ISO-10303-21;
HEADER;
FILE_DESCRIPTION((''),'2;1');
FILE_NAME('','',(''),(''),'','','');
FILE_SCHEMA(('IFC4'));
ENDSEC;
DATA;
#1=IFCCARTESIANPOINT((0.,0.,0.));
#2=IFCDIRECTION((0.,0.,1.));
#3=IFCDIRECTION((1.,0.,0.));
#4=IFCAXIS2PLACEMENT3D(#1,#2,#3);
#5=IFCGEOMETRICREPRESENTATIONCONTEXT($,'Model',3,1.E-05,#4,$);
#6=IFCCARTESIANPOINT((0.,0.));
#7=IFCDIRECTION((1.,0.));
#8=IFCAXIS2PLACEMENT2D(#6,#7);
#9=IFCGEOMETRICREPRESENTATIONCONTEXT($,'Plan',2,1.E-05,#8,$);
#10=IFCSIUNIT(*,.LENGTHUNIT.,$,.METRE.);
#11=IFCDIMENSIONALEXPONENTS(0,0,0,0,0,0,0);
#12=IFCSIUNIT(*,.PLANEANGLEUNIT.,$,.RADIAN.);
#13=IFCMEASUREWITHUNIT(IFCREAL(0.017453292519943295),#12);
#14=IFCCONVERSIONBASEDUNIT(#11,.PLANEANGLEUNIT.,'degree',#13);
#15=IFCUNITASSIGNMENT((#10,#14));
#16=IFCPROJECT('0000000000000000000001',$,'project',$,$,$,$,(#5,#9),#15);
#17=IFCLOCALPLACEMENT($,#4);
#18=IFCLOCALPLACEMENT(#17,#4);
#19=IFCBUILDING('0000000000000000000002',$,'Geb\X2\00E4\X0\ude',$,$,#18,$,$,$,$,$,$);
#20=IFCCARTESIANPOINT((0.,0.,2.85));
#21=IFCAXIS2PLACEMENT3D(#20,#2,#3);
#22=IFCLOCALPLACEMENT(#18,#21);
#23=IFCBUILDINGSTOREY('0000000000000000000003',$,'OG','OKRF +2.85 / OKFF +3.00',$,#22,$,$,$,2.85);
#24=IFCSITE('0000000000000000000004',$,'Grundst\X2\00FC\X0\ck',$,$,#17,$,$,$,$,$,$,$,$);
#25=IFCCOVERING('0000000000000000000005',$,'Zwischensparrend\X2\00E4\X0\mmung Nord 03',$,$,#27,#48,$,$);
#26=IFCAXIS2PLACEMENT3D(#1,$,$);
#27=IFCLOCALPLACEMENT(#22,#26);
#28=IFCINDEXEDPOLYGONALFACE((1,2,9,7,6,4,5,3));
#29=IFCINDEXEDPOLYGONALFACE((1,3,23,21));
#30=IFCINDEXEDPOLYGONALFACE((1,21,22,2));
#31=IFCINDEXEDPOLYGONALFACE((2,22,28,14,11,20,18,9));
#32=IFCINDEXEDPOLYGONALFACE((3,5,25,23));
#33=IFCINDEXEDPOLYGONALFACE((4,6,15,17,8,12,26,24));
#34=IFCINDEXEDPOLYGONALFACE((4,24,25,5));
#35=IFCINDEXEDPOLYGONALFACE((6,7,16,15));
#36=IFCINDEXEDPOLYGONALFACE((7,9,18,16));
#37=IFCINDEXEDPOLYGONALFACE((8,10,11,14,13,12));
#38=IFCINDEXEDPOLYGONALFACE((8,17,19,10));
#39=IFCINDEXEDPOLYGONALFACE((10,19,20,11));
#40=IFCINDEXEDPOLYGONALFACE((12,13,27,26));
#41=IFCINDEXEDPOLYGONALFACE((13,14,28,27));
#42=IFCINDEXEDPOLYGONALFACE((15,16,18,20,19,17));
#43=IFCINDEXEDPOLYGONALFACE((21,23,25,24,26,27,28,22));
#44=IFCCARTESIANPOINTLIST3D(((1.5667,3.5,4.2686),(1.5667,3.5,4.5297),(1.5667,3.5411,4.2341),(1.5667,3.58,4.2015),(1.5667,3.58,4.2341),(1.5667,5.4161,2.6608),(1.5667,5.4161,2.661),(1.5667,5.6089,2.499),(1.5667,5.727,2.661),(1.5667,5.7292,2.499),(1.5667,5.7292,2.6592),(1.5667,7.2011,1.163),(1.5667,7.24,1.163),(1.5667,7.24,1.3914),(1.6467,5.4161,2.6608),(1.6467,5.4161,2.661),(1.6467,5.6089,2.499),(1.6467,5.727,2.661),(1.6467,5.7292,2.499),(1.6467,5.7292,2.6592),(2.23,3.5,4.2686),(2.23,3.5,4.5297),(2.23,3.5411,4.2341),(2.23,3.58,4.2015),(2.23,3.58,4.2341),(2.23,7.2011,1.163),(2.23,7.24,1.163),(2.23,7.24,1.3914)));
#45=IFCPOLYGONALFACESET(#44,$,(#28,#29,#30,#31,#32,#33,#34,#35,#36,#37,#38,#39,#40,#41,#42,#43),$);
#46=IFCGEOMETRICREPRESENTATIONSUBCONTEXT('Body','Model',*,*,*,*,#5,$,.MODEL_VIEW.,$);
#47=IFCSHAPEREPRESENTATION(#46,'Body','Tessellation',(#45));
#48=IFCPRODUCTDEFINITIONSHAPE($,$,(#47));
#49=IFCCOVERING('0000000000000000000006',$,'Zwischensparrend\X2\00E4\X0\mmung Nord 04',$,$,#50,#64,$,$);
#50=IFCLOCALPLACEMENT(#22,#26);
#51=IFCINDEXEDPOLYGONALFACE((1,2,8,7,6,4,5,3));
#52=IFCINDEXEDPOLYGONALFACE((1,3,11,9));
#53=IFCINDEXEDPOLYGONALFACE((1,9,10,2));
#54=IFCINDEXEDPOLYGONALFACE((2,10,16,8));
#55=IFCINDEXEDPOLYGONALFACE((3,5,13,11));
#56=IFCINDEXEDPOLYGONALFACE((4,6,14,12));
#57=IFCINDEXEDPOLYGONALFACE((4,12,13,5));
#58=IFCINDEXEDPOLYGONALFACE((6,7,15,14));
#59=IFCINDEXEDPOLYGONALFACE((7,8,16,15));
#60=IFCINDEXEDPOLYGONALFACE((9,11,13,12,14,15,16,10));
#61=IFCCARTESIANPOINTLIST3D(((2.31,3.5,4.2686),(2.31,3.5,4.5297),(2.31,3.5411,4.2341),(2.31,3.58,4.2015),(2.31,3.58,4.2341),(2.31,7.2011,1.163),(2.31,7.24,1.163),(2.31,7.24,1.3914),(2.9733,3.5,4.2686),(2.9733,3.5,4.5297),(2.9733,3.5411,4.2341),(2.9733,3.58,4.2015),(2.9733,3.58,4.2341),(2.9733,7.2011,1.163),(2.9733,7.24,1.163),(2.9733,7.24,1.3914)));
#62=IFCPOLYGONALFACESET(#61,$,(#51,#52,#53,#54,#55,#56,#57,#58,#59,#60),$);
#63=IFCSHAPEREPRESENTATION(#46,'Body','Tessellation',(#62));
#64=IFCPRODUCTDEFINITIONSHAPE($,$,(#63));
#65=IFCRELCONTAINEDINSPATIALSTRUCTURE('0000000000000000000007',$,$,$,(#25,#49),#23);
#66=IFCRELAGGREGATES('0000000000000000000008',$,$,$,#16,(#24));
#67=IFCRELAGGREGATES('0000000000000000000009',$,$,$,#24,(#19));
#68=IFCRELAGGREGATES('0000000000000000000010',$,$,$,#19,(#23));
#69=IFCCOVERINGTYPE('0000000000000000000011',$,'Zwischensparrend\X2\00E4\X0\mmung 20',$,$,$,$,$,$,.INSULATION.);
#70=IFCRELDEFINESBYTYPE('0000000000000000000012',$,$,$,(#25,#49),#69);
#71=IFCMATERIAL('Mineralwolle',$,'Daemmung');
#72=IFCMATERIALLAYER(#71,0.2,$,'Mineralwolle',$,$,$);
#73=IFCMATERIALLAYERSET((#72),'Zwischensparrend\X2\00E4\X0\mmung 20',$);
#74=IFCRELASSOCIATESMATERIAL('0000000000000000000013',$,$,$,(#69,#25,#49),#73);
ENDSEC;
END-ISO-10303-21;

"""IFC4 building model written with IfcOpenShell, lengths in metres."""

from ifc_helpers import new_model, entity, si_unit, converted_unit, frame, origin_with_axes, origin_2d_with_axis, place, context, subcontext, project, spatial, polyline, outline, extrude, material, layer, layer_set, layer_usage, type_object, element, save


model = new_model("IFC4")

# Units and contexts
model_context = context("Model", 3, precision=1e-05, world=origin_with_axes())
plan_context = context("Plan", 2, precision=1e-05, world=origin_2d_with_axis())
body_context = subcontext(model_context, "Body", "Model", "MODEL_VIEW")
ifc_project = project(units=[si_unit("LENGTHUNIT", "METRE"), converted_unit("PLANEANGLEUNIT", "degree", entity("IfcReal", 0.017453292519943295), si_unit("PLANEANGLEUNIT", "RADIAN"), dimensions=[0, 0, 0, 0, 0, 0, 0])], contexts=[model_context, plan_context])

# Site, building, storey
site_placement = place(None, origin_with_axes())
site = spatial("IfcSite", under=ifc_project, at=site_placement, Name="Grundstück")
building_placement = place(site_placement, origin_with_axes())
building = spatial("IfcBuilding", under=site, at=building_placement, Name="Gebäude")
storey_placement = place(building_placement, frame((0.0, 0.0, 2.85), z_axis=(0.0, 0.0, 1.0), x_axis=(1.0, 0.0, 0.0)))
storey = spatial("IfcBuildingStorey", under=building, at=storey_placement, Name="OG", Description="OKRF +2.85 / OKFF +3.00", Elevation=2.85)

# Covering, opening
ifc_material_1 = material(Name="Mineralwolle", Category="Daemmung")
ifc_layer = layer(ifc_material_1, 0.2, Name="Mineralwolle")
ifc_layer_set = layer_set([ifc_layer], Name="Zwischensparrendämmung 20")
ifc_layer_usage_1 = layer_usage(ifc_layer_set, "AXIS3", "POSITIVE", 0.0)
covering_type = type_object("IfcCoveringType", Name="Zwischensparrendämmung 20", PredefinedType="INSULATION", material=ifc_layer_set)
covering_1_placement = place(storey_placement, frame((2.23, 7.24, 1.1304), z_axis=(0.0, 0.642788, 0.766044), x_axis=(-1.0, 0.0, 0.0)))
covering_1 = element("IfcCovering", 1, at=covering_1_placement, inside=storey, type_object=covering_type, material=ifc_layer_usage_1, Name="Zwischensparrendämmung Nord 03", context=body_context, shape_type="SweptSolid", body=[
    extrude(outline(polyline([(0.021, 0.025), (0.0508, 0.0), (4.7778, 0.0), (4.7988, 0.025), (4.8286, 0.0), (4.8822, 0.0), (5.05, 0.2), (0.1678, 0.2), (0.021, 0.025)])), frame((0.0, 0.0, 0.0), z_axis=(1.0, 0.0, 0.0), x_axis=(0.0, 1.0, 0.0)), (0.0, 0.0, 1.0), 0.6633),
])
opening_1_placement = place(covering_1_placement, frame((2.23, 2.9876, -7.7029), z_axis=(0.0, 0.642788, 0.766044), x_axis=(-1.0, 0.0, 0.0)))
element("IfcOpeningElement", 2, at=opening_1_placement, cuts=covering_1, PredefinedType="RECESS", context=body_context, shape_type="SweptSolid", body=[
    extrude(outline(polyline([(1.5667, 5.4161), (1.6467, 5.4161), (1.6467, 5.7292), (1.5667, 5.7292), (1.5667, 5.4161)])), frame((0.0, 0.0, 5.349), z_axis=(0.0, 0.0, 1.0), x_axis=(1.0, 0.0, 0.0)), (0.0, 0.0, 1.0), 0.162),
])

# Covering
ifc_layer_usage_2 = layer_usage(ifc_layer_set, "AXIS3", "POSITIVE", 0.0)
covering_2_placement = place(storey_placement, frame((2.9733, 7.24, 1.1304), z_axis=(0.0, 0.642788, 0.766044), x_axis=(-1.0, 0.0, 0.0)))
element("IfcCovering", 3, at=covering_2_placement, inside=storey, type_object=covering_type, material=ifc_layer_usage_2, Name="Zwischensparrendämmung Nord 04", context=body_context, shape_type="SweptSolid", body=[
    extrude(outline(polyline([(0.021, 0.025), (0.0508, 0.0), (4.7778, 0.0), (4.7988, 0.025), (4.8286, 0.0), (4.8822, 0.0), (5.05, 0.2), (0.1678, 0.2), (0.021, 0.025)])), frame((0.0, 0.0, 0.0), z_axis=(1.0, 0.0, 0.0), x_axis=(0.0, 1.0, 0.0)), (0.0, 0.0, 1.0), 0.6633),
])

save(model, "model.ifc")
